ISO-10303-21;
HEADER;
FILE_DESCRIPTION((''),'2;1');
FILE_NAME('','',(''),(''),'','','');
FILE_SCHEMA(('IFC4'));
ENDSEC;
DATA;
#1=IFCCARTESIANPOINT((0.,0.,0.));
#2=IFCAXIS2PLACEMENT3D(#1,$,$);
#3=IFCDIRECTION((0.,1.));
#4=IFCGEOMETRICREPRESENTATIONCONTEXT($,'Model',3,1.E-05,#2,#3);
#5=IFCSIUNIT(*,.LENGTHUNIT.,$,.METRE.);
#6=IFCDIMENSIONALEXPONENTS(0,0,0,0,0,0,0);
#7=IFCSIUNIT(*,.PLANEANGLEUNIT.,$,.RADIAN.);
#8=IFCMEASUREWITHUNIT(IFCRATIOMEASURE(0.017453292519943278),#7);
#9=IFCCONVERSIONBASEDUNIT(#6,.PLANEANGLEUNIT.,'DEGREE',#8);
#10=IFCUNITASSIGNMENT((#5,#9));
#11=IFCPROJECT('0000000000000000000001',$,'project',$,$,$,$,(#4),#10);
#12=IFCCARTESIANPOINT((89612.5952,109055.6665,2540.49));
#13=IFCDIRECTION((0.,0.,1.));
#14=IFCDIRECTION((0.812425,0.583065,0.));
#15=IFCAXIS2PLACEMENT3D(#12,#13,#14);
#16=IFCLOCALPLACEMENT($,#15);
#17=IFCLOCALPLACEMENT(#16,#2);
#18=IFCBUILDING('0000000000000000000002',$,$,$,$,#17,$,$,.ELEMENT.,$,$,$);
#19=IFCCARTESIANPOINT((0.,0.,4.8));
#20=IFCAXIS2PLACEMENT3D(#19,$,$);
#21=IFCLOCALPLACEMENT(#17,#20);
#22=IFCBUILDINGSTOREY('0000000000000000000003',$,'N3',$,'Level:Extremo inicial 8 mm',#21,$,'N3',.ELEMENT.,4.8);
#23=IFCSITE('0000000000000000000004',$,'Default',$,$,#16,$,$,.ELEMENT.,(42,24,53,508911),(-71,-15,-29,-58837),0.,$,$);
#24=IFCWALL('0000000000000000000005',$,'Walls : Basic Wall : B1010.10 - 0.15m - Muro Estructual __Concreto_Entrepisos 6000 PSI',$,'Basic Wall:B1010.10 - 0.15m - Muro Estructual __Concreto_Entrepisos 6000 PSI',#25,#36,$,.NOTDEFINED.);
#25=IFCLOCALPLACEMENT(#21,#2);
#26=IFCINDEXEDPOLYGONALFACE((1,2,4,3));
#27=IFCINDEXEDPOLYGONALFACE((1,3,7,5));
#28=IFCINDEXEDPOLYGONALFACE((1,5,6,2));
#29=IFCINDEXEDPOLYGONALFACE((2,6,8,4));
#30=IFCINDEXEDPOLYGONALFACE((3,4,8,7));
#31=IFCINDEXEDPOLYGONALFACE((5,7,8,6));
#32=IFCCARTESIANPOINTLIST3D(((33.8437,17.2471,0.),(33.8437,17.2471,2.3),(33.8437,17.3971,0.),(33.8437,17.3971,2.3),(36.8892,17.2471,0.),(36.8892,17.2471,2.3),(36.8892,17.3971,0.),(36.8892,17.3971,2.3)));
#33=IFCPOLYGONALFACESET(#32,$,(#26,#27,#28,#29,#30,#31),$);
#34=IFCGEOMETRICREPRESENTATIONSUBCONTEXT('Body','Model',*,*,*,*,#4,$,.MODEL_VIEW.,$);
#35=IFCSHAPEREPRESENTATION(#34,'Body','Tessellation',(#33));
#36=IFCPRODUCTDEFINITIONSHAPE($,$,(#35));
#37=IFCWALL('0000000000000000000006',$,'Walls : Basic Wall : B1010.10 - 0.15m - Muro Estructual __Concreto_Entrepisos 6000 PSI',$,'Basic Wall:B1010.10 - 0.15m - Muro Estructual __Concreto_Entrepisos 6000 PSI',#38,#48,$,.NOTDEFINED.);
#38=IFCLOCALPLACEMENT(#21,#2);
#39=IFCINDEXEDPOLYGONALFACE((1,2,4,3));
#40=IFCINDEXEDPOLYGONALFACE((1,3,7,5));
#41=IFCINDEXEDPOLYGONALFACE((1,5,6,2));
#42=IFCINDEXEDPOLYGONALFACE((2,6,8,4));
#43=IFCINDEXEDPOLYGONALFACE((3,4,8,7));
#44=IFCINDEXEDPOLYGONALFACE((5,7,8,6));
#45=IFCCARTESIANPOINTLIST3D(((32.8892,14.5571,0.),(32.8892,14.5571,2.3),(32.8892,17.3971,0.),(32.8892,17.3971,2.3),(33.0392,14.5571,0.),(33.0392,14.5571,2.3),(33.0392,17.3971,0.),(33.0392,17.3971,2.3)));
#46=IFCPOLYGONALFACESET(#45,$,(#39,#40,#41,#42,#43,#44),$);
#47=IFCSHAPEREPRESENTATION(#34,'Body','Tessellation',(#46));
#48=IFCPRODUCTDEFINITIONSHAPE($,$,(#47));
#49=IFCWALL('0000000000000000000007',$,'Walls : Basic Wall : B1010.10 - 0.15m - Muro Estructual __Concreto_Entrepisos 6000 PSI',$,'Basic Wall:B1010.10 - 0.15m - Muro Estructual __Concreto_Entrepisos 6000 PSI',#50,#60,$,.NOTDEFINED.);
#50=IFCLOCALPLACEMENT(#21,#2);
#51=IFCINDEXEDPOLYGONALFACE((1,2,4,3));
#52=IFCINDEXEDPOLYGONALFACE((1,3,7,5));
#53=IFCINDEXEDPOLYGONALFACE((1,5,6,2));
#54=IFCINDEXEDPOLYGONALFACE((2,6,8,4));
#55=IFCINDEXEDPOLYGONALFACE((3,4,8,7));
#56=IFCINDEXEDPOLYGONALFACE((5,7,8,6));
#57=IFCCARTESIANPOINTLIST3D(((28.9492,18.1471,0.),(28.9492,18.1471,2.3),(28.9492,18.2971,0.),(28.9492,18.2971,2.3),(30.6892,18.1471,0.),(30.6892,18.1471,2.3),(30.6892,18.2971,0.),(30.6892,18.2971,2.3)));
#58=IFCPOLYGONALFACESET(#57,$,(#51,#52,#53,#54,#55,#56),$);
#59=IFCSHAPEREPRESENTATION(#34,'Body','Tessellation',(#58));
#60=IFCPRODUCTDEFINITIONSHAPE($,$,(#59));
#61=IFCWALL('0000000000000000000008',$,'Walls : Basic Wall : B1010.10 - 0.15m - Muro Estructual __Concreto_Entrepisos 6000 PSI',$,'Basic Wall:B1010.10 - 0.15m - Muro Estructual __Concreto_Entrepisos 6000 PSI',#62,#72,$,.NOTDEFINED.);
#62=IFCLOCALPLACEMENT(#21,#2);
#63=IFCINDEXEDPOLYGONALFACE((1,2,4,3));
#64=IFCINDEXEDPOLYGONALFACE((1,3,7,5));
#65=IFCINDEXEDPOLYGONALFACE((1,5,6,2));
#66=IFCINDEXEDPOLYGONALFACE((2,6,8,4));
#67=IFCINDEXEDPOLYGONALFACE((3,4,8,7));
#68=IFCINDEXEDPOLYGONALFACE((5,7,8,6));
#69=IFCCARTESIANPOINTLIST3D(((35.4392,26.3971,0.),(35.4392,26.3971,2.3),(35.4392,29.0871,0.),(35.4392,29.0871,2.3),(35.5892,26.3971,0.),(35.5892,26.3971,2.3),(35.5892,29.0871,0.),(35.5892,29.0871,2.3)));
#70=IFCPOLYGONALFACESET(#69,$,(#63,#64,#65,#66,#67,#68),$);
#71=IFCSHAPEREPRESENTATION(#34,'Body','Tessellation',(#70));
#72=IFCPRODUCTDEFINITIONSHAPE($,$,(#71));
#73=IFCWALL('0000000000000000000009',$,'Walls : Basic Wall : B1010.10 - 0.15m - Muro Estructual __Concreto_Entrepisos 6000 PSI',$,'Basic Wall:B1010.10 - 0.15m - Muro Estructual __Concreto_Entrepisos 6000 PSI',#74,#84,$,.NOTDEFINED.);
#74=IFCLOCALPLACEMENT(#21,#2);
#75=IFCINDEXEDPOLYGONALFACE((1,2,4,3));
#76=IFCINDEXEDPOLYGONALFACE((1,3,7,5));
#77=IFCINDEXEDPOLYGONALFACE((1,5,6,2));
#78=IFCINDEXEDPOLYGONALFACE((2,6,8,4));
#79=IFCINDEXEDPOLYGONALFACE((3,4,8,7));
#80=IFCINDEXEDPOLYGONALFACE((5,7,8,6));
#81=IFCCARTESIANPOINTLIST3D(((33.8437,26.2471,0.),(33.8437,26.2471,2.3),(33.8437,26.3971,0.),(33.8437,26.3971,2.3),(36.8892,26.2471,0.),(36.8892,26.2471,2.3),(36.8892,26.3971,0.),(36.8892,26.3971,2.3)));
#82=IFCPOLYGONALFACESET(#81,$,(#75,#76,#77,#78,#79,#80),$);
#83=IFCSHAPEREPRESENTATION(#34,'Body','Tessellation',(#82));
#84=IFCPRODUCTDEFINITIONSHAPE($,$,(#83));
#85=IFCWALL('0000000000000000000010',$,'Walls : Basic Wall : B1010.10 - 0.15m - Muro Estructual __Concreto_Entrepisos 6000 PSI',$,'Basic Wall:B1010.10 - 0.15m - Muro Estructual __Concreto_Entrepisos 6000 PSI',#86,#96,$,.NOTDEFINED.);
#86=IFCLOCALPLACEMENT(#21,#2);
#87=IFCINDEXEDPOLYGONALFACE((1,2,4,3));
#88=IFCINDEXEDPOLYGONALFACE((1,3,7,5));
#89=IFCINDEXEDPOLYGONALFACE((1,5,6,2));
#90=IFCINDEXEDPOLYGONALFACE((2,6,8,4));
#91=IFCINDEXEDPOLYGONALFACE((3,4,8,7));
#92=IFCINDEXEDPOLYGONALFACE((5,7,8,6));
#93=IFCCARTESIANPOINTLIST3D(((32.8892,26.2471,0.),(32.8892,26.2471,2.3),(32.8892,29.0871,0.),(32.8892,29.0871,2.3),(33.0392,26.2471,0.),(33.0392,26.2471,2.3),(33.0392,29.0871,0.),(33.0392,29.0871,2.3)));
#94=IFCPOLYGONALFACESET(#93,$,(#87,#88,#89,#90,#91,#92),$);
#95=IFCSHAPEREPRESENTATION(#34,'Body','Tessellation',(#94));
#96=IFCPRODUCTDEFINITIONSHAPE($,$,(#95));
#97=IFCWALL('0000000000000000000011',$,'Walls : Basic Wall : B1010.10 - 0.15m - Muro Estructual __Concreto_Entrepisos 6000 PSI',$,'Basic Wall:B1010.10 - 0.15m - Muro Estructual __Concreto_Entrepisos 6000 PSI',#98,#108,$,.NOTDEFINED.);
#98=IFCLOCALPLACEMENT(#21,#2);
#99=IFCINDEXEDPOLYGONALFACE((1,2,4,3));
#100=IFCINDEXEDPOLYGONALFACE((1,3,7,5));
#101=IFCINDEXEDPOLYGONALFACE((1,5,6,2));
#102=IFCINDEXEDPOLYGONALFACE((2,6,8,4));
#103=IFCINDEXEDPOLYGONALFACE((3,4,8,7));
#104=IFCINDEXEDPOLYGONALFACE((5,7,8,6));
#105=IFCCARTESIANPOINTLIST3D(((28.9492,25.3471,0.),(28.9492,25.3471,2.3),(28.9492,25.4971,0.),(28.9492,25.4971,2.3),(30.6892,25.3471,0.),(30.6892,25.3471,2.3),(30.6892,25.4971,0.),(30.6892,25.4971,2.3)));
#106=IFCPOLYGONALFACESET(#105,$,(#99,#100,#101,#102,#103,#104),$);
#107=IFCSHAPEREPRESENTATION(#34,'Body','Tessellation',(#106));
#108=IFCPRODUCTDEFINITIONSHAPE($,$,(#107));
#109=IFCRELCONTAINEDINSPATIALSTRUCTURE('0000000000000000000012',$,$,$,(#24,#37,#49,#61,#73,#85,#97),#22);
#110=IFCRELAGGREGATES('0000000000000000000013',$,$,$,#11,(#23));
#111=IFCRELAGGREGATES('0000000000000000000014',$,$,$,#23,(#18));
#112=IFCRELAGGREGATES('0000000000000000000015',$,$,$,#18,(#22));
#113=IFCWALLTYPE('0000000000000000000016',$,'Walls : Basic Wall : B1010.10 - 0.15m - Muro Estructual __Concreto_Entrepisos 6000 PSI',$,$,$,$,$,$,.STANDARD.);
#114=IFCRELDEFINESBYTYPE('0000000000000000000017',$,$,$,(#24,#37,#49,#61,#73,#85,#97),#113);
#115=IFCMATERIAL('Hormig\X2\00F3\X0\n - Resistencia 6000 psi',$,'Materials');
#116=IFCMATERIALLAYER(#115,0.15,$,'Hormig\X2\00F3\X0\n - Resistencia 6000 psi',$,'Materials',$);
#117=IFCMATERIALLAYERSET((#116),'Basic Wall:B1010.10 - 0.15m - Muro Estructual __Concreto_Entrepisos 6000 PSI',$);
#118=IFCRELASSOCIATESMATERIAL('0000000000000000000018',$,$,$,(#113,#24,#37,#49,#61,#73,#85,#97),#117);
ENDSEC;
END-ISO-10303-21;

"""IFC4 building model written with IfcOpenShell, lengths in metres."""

from ifc_helpers import new_model, entity, si_unit, converted_unit, direction, frame, frame_2d, origin, place, context, subcontext, project, spatial, rectangle, extrude, material, layer, layer_set, layer_usage, type_object, element, save


model = new_model("IFC4")

# Units and contexts
model_context = context("Model", 3, precision=1e-05, world=origin(), true_north=direction((0.0, 1.0)))
body_context = subcontext(model_context, "Body", "Model", "MODEL_VIEW")
ifc_project = project(units=[si_unit("LENGTHUNIT", "METRE"), converted_unit("PLANEANGLEUNIT", "DEGREE", entity("IfcRatioMeasure", 0.017453292519943278), si_unit("PLANEANGLEUNIT", "RADIAN"), dimensions=[0, 0, 0, 0, 0, 0, 0])], contexts=[model_context])

# Site, building, storey
site_placement = place(None, frame((89612.5952, 109055.6665, 2540.49), z_axis=(0.0, 0.0, 1.0), x_axis=(0.812425, 0.583065, 0.0)))
site = spatial("IfcSite", under=ifc_project, at=site_placement, Name="Default", CompositionType="ELEMENT", RefLatitude=(42, 24, 53, 508911), RefLongitude=(-71, -15, -29, -58837), RefElevation=0.0)
building_placement = place(site_placement, origin())
building = spatial("IfcBuilding", under=site, at=building_placement, CompositionType="ELEMENT")
storey_placement = place(building_placement, frame((0.0, 0.0, 4.8)))
storey = spatial("IfcBuildingStorey", under=building, at=storey_placement, Name="N3", ObjectType="Level:Extremo inicial 8 mm", LongName="N3", CompositionType="ELEMENT", Elevation=4.8)

# Walls
ifc_material = material(Name="Hormigón - Resistencia 6000 psi", Category="Materials")
ifc_layer_1 = layer(ifc_material, 0.15, Name="Hormigón - Resistencia 6000 psi", Category="Materials")
ifc_layer_set_1 = layer_set([ifc_layer_1], Name="Basic Wall:B1010.10 - 0.15m - Muro Estructual __Concreto_Entrepisos 6000 PSI")
wall_type_1 = type_object("IfcWallType", Name="Walls : Basic Wall : B1010.10 - 0.15m - Muro Estructual __Concreto_Entrepisos 6000 PSI", PredefinedType="STANDARD", material=ifc_layer_set_1)
ifc_layer_usage_1 = layer_usage(ifc_layer_set_1, "AXIS2", "NEGATIVE", 0.075)
wall_1_placement = place(storey_placement, frame((36.8892, 17.3221, 0.0), z_axis=(0.0, 0.0, 1.0), x_axis=(-1.0, 0.0, 0.0)))
element("IfcWall", 1, at=wall_1_placement, inside=storey, type_object=wall_type_1, material=ifc_layer_usage_1, Name="Walls : Basic Wall : B1010.10 - 0.15m - Muro Estructual __Concreto_Entrepisos 6000 PSI", ObjectType="Basic Wall:B1010.10 - 0.15m - Muro Estructual __Concreto_Entrepisos 6000 PSI", PredefinedType="NOTDEFINED", context=body_context, shape_type="SweptSolid", body=[
    extrude(rectangle(XDim=3.0455, YDim=0.15, at=frame_2d((1.5228, 0.0), x_axis=(-1.0, 0.0))), origin(), (0.0, 0.0, 1.0), 2.3),
])
ifc_layer_usage_2 = layer_usage(ifc_layer_set_1, "AXIS2", "NEGATIVE", 0.075)
wall_2_placement = place(storey_placement, frame((32.9642, 14.5571, 0.0), z_axis=(0.0, 0.0, 1.0), x_axis=(0.0, 1.0, 0.0)))
element("IfcWall", 2, at=wall_2_placement, inside=storey, type_object=wall_type_1, material=ifc_layer_usage_2, Name="Walls : Basic Wall : B1010.10 - 0.15m - Muro Estructual __Concreto_Entrepisos 6000 PSI", ObjectType="Basic Wall:B1010.10 - 0.15m - Muro Estructual __Concreto_Entrepisos 6000 PSI", PredefinedType="NOTDEFINED", context=body_context, shape_type="SweptSolid", body=[
    extrude(rectangle(XDim=2.84, YDim=0.15, at=frame_2d((1.42, 0.0), x_axis=(-1.0, 0.0))), origin(), (0.0, 0.0, 1.0), 2.3),
])
ifc_layer_usage_3 = layer_usage(ifc_layer_set_1, "AXIS2", "NEGATIVE", 0.075)
wall_3_placement = place(storey_placement, frame((30.6892, 18.2221, 0.0), z_axis=(0.0, 0.0, 1.0), x_axis=(-1.0, 0.0, 0.0)))
element("IfcWall", 3, at=wall_3_placement, inside=storey, type_object=wall_type_1, material=ifc_layer_usage_3, Name="Walls : Basic Wall : B1010.10 - 0.15m - Muro Estructual __Concreto_Entrepisos 6000 PSI", ObjectType="Basic Wall:B1010.10 - 0.15m - Muro Estructual __Concreto_Entrepisos 6000 PSI", PredefinedType="NOTDEFINED", context=body_context, shape_type="SweptSolid", body=[
    extrude(rectangle(XDim=1.74, YDim=0.15, at=frame_2d((0.87, 0.0), x_axis=(-1.0, 0.0))), origin(), (0.0, 0.0, 1.0), 2.3),
])
ifc_layer_usage_4 = layer_usage(ifc_layer_set_1, "AXIS2", "POSITIVE", -0.075)
wall_4_placement = place(storey_placement, frame((35.5142, 29.0871, 0.0), z_axis=(0.0, 0.0, 1.0), x_axis=(0.0, -1.0, 0.0)))
element("IfcWall", 4, at=wall_4_placement, inside=storey, type_object=wall_type_1, material=ifc_layer_usage_4, Name="Walls : Basic Wall : B1010.10 - 0.15m - Muro Estructual __Concreto_Entrepisos 6000 PSI", ObjectType="Basic Wall:B1010.10 - 0.15m - Muro Estructual __Concreto_Entrepisos 6000 PSI", PredefinedType="NOTDEFINED", context=body_context, shape_type="SweptSolid", body=[
    extrude(rectangle(XDim=2.69, YDim=0.15, at=frame_2d((1.345, 0.0), x_axis=(-1.0, 0.0))), origin(), (0.0, 0.0, 1.0), 2.3),
])
ifc_layer_usage_5 = layer_usage(ifc_layer_set_1, "AXIS2", "POSITIVE", -0.075)
wall_5_placement = place(storey_placement, frame((36.8892, 26.3221, 0.0), z_axis=(0.0, 0.0, 1.0), x_axis=(-1.0, 0.0, 0.0)))
element("IfcWall", 5, at=wall_5_placement, inside=storey, type_object=wall_type_1, material=ifc_layer_usage_5, Name="Walls : Basic Wall : B1010.10 - 0.15m - Muro Estructual __Concreto_Entrepisos 6000 PSI", ObjectType="Basic Wall:B1010.10 - 0.15m - Muro Estructual __Concreto_Entrepisos 6000 PSI", PredefinedType="NOTDEFINED", context=body_context, shape_type="SweptSolid", body=[
    extrude(rectangle(XDim=3.0455, YDim=0.15, at=frame_2d((1.5228, 0.0), x_axis=(-1.0, 0.0))), origin(), (0.0, 0.0, 1.0), 2.3),
])
ifc_layer_usage_6 = layer_usage(ifc_layer_set_1, "AXIS2", "POSITIVE", -0.075)
wall_6_placement = place(storey_placement, frame((32.9642, 29.0871, 0.0), z_axis=(0.0, 0.0, 1.0), x_axis=(0.0, -1.0, 0.0)))
element("IfcWall", 6, at=wall_6_placement, inside=storey, type_object=wall_type_1, material=ifc_layer_usage_6, Name="Walls : Basic Wall : B1010.10 - 0.15m - Muro Estructual __Concreto_Entrepisos 6000 PSI", ObjectType="Basic Wall:B1010.10 - 0.15m - Muro Estructual __Concreto_Entrepisos 6000 PSI", PredefinedType="NOTDEFINED", context=body_context, shape_type="SweptSolid", body=[
    extrude(rectangle(XDim=2.84, YDim=0.15, at=frame_2d((1.42, 0.0), x_axis=(-1.0, 0.0))), origin(), (0.0, 0.0, 1.0), 2.3),
])
ifc_layer_usage_7 = layer_usage(ifc_layer_set_1, "AXIS2", "POSITIVE", -0.075)
wall_7_placement = place(storey_placement, frame((30.6892, 25.4221, 0.0), z_axis=(0.0, 0.0, 1.0), x_axis=(-1.0, 0.0, 0.0)))
element("IfcWall", 7, at=wall_7_placement, inside=storey, type_object=wall_type_1, material=ifc_layer_usage_7, Name="Walls : Basic Wall : B1010.10 - 0.15m - Muro Estructual __Concreto_Entrepisos 6000 PSI", ObjectType="Basic Wall:B1010.10 - 0.15m - Muro Estructual __Concreto_Entrepisos 6000 PSI", PredefinedType="NOTDEFINED", context=body_context, shape_type="SweptSolid", body=[
    extrude(rectangle(XDim=1.74, YDim=0.15, at=frame_2d((0.87, 0.0), x_axis=(-1.0, 0.0))), origin(), (0.0, 0.0, 1.0), 2.3),
])

save(model, "model.ifc")
